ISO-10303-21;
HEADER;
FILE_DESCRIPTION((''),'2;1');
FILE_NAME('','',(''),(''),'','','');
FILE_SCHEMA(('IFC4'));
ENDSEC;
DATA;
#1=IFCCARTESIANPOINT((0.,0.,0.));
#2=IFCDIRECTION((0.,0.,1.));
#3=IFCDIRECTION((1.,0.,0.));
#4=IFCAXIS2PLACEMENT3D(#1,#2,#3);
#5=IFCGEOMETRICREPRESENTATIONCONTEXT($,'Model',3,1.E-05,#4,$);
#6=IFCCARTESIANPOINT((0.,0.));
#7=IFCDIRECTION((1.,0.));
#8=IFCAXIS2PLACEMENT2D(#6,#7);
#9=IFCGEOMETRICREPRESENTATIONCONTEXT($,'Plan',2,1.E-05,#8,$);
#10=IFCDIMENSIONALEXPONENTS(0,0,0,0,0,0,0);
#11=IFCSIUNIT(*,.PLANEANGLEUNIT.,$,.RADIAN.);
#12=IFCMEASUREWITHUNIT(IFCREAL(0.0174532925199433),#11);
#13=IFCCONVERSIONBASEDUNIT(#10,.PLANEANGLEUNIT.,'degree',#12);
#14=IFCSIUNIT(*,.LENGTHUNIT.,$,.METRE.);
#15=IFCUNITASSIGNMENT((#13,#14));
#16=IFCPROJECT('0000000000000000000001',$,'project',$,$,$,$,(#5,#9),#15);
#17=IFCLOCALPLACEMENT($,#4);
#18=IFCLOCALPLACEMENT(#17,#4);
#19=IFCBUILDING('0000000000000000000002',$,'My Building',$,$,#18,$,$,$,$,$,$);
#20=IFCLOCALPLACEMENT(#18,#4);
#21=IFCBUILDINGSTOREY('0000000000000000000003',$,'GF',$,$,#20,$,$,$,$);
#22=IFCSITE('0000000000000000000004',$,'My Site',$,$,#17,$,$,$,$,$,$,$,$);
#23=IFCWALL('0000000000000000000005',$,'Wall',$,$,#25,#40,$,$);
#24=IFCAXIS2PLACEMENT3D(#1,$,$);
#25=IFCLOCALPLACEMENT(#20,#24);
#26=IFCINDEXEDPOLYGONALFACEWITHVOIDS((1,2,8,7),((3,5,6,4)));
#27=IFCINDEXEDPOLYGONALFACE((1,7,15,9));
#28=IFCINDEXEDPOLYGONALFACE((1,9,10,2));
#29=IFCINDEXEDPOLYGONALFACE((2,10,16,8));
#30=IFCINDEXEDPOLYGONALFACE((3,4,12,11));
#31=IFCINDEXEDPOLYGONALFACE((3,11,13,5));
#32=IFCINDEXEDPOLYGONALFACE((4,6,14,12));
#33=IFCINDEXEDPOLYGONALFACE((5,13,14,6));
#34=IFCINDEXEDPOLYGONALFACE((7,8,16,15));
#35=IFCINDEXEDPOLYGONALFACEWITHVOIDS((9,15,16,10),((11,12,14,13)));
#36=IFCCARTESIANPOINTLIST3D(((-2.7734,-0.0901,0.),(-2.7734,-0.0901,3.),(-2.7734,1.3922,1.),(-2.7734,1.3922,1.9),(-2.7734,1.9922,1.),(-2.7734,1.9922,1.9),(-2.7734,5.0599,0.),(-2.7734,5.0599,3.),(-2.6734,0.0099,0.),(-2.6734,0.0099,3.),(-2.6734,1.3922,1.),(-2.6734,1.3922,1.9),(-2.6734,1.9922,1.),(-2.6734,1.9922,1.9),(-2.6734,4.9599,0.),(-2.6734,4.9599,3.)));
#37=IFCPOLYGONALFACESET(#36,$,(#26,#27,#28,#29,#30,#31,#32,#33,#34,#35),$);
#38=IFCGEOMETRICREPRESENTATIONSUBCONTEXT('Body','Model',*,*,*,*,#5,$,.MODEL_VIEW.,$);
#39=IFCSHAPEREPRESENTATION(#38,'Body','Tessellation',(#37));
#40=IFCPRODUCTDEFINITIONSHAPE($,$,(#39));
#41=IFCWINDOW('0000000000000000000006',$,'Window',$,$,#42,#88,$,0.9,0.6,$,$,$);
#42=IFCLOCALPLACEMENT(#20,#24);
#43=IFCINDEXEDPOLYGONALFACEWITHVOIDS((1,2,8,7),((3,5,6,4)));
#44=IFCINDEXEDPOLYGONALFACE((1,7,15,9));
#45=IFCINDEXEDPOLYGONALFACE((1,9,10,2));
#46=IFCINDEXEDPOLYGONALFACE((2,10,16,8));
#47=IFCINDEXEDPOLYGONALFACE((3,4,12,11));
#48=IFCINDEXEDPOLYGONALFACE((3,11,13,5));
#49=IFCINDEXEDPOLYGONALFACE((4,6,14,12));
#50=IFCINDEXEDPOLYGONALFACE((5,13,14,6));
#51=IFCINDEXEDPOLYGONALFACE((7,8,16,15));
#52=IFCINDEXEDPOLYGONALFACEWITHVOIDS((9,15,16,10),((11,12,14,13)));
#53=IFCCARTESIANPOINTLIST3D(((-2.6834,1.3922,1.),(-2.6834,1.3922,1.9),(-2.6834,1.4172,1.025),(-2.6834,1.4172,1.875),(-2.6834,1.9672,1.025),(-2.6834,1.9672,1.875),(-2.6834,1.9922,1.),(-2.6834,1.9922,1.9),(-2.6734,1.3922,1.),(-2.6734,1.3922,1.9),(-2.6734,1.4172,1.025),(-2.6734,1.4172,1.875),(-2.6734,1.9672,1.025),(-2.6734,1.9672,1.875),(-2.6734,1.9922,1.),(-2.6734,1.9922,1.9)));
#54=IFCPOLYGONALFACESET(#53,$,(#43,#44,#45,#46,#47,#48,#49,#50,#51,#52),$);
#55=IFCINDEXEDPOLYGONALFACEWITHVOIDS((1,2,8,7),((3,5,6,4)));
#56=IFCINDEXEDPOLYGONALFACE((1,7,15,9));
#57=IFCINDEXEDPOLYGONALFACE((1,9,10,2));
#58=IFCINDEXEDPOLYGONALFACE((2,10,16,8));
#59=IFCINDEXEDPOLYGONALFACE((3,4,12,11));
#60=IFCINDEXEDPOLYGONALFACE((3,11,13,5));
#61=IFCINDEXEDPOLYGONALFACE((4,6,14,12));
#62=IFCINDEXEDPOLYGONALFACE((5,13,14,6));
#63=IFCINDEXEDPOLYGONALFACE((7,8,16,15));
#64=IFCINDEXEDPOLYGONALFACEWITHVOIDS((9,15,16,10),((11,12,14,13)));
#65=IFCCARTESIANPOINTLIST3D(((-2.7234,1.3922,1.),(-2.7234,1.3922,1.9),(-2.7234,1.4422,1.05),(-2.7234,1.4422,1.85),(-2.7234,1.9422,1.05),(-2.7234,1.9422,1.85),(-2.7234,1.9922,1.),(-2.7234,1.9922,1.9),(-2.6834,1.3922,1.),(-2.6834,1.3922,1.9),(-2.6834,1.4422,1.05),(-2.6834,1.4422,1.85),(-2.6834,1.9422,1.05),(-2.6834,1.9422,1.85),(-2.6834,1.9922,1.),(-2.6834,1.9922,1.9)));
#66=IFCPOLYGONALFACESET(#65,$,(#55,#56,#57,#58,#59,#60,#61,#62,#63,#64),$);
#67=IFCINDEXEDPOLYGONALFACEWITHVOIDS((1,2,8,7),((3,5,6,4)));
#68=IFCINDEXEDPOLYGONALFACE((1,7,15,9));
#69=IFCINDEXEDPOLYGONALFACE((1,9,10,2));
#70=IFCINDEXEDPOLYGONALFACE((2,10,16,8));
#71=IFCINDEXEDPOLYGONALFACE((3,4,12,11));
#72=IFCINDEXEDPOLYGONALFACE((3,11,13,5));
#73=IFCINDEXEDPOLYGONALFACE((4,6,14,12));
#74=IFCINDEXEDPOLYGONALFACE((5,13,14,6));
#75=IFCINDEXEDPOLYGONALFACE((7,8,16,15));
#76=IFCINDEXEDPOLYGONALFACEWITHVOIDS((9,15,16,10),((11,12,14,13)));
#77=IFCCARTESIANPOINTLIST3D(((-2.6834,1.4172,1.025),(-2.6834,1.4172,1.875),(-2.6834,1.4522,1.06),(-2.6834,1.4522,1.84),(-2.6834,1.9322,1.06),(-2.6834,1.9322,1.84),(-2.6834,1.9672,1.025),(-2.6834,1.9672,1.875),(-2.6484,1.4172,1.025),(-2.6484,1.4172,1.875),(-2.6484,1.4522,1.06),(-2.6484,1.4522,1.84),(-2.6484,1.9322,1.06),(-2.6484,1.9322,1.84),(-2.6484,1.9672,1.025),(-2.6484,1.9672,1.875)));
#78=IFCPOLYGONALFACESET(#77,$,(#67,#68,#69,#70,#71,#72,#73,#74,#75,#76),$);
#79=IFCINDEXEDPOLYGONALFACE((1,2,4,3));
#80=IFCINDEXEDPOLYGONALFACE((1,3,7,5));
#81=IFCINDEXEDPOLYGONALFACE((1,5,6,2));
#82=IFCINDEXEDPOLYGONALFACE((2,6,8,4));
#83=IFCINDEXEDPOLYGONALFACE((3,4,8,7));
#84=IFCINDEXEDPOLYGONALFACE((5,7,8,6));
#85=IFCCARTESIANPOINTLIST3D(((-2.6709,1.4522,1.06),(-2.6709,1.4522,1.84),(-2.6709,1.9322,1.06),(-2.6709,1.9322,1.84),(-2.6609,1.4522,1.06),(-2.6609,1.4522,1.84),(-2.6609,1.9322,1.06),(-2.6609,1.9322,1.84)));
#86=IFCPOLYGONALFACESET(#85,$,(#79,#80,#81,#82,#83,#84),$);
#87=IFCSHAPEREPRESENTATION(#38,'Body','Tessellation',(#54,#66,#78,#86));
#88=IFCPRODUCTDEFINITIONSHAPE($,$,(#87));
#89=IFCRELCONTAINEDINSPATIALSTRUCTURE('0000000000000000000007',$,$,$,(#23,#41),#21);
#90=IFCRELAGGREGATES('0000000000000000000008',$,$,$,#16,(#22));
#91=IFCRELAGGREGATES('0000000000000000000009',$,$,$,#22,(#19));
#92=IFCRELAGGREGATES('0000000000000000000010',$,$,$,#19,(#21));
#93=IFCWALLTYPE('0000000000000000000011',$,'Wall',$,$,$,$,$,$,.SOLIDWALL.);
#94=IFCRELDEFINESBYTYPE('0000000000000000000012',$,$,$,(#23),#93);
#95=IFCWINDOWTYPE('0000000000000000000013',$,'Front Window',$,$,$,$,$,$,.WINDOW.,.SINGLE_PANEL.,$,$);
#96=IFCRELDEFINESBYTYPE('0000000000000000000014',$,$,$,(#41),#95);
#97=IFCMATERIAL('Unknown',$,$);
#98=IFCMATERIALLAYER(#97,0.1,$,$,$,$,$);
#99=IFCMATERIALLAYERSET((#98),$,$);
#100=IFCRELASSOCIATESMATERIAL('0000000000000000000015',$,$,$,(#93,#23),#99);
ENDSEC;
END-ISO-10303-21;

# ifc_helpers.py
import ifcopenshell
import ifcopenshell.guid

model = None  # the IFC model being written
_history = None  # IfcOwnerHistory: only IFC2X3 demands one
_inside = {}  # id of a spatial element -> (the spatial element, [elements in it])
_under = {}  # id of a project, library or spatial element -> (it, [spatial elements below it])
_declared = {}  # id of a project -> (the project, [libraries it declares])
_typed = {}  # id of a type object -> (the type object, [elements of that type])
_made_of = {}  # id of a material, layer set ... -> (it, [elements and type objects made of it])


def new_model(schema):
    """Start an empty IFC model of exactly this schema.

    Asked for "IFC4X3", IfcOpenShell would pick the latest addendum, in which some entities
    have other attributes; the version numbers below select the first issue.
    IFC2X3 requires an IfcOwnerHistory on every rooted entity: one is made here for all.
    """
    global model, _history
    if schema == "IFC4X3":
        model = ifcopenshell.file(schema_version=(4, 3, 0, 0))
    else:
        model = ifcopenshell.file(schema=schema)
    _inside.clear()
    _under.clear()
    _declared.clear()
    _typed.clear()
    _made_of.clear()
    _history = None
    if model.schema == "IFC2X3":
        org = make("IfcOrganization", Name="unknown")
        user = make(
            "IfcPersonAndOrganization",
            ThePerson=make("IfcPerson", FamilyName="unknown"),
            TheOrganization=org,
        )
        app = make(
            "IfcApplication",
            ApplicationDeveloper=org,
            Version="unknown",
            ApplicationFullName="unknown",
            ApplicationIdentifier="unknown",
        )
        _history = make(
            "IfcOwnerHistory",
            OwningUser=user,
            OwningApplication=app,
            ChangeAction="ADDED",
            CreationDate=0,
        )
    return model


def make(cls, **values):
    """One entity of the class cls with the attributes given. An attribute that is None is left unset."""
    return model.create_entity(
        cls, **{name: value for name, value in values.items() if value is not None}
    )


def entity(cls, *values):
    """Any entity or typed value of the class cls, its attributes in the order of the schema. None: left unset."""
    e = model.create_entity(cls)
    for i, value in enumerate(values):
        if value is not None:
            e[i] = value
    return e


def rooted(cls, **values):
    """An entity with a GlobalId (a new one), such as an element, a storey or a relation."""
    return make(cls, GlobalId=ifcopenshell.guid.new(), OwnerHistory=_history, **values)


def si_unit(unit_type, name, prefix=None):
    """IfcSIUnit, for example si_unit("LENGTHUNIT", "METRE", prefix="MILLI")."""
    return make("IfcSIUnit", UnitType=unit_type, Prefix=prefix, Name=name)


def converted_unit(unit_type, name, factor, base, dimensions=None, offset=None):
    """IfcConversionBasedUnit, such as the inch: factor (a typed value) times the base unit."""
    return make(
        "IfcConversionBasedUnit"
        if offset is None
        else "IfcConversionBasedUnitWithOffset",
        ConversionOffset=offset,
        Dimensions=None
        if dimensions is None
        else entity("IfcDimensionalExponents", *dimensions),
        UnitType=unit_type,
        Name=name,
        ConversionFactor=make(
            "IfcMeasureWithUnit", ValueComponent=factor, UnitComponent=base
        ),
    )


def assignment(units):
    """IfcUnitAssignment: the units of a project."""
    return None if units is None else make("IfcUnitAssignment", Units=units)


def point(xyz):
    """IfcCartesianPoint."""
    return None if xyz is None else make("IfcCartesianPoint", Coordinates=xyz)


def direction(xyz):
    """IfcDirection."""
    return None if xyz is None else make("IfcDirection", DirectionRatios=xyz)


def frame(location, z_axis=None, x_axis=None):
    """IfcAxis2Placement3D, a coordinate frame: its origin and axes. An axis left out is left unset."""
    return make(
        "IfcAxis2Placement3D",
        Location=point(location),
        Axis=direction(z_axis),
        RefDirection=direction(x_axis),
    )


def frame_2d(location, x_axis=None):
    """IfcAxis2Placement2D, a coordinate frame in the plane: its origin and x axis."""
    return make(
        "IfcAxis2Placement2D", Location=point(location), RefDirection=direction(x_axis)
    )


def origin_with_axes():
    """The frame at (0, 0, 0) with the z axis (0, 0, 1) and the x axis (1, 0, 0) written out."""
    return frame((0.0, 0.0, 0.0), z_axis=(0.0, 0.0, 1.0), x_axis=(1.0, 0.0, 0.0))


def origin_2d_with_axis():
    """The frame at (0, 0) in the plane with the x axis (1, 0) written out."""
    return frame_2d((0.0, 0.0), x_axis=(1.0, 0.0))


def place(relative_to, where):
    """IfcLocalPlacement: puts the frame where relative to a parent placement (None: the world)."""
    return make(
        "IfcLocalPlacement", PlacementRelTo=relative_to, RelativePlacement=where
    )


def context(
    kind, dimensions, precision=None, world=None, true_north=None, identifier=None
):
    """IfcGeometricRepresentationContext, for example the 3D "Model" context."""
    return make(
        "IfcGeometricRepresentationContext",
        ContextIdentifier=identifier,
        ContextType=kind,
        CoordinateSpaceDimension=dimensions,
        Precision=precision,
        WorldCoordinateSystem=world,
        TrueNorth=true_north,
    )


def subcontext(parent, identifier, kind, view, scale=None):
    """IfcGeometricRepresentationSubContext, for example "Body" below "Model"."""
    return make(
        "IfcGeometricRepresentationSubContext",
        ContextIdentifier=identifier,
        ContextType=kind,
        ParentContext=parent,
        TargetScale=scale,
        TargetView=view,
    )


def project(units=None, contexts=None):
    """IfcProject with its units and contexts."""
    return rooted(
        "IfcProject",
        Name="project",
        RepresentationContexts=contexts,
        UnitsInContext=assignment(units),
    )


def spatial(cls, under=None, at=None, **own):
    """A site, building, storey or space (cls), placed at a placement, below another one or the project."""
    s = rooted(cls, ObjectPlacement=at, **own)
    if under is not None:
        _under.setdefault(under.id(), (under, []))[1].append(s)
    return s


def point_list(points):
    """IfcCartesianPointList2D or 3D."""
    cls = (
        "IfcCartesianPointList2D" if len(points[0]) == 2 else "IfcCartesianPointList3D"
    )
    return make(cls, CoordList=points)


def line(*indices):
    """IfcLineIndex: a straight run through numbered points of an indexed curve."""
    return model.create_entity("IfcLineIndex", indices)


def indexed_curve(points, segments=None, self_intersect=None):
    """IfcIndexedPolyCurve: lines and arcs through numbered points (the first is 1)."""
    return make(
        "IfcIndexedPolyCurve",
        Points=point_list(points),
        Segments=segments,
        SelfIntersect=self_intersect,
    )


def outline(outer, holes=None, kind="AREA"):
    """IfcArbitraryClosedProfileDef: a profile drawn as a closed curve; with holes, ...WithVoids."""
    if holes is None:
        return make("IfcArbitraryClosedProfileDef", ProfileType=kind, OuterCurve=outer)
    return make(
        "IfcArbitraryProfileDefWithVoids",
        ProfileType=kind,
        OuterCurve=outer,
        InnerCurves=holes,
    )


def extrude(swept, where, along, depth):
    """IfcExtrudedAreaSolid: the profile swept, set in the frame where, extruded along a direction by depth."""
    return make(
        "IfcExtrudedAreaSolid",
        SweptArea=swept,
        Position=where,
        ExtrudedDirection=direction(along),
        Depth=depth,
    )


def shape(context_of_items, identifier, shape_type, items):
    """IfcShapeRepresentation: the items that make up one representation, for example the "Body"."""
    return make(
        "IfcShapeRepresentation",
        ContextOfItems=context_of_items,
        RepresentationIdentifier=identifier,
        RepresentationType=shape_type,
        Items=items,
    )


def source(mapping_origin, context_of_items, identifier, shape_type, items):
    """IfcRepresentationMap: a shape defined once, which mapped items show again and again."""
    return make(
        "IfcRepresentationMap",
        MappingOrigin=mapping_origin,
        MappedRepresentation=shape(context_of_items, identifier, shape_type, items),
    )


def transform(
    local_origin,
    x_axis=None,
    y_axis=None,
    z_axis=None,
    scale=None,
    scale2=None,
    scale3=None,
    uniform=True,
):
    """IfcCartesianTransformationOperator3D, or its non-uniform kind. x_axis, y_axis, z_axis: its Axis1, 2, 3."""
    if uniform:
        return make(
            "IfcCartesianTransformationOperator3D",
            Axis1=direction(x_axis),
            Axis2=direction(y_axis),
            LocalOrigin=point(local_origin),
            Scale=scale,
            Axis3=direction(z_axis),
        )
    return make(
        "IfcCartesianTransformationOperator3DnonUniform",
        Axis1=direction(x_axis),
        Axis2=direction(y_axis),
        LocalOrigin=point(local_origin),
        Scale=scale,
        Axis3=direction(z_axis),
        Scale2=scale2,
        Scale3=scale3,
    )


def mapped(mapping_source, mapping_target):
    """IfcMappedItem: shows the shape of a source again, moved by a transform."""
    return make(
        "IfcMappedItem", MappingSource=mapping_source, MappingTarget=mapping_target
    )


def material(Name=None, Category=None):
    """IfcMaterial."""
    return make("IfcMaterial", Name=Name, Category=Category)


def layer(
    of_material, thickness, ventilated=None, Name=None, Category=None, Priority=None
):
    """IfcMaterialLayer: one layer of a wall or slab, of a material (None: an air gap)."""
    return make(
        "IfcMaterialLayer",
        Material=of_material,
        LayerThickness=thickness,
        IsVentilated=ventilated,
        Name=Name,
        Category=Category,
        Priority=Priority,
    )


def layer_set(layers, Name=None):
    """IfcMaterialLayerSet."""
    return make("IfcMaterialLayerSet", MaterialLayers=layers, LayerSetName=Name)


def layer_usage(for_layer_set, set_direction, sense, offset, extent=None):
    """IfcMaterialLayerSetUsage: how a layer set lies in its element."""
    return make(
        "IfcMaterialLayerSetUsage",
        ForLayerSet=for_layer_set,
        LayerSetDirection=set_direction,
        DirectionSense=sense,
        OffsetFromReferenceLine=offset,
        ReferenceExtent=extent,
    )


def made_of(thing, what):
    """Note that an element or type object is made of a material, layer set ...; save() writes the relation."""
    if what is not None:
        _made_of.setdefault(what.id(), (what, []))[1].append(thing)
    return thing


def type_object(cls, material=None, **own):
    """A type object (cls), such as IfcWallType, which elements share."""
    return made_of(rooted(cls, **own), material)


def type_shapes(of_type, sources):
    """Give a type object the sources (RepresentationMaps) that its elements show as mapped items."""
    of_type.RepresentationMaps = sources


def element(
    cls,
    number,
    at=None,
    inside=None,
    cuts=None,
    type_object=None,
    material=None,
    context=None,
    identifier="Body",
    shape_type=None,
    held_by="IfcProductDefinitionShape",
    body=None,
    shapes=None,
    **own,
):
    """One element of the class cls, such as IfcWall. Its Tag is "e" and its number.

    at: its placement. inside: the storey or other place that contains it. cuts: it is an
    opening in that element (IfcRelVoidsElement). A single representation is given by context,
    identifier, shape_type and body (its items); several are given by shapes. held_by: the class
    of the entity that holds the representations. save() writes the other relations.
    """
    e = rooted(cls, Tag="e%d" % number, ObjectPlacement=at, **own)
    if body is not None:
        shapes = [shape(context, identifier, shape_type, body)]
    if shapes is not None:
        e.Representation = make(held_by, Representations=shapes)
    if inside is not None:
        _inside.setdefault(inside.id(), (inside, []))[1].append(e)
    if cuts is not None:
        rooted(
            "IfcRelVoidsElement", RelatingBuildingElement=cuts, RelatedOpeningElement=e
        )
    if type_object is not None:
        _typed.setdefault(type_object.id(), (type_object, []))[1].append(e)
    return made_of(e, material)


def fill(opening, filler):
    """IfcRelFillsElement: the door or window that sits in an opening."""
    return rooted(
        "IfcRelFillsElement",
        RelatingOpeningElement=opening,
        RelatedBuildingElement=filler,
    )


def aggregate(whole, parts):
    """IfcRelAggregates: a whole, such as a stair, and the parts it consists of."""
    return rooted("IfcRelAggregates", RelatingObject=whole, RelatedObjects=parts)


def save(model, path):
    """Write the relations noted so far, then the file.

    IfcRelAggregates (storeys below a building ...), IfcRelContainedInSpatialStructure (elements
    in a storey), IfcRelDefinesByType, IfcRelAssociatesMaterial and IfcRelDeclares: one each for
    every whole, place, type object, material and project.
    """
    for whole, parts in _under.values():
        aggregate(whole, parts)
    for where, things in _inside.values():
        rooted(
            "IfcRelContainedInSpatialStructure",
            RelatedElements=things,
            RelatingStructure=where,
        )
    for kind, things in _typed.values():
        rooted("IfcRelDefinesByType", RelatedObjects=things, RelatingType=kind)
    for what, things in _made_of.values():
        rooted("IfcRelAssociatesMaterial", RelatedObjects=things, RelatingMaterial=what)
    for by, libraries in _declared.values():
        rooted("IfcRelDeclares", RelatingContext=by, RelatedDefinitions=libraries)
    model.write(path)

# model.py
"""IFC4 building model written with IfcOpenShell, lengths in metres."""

from ifc_helpers import new_model, entity, si_unit, converted_unit, frame, origin_with_axes, origin_2d_with_axis, place, context, subcontext, project, spatial, line, indexed_curve, outline, extrude, shape, source, transform, mapped, material, layer, layer_set, layer_usage, type_object, type_shapes, element, fill, save


model = new_model("IFC4")

# Units and contexts
model_context = context("Model", 3, precision=1e-05, world=origin_with_axes())
plan_context = context("Plan", 2, precision=1e-05, world=origin_2d_with_axis())
body_context_1 = subcontext(model_context, "Body", "Model", "MODEL_VIEW")
body_context_2 = subcontext(plan_context, "Body", "Plan", "PLAN_VIEW")
ifc_project = project(units=[converted_unit("PLANEANGLEUNIT", "degree", entity("IfcReal", 0.0174532925199433), si_unit("PLANEANGLEUNIT", "RADIAN"), dimensions=[0, 0, 0, 0, 0, 0, 0]), si_unit("LENGTHUNIT", "METRE")], contexts=[model_context, plan_context])

# Site, building, storey
site_placement = place(None, origin_with_axes())
site = spatial("IfcSite", under=ifc_project, at=site_placement, Name="My Site")
building_placement = place(site_placement, origin_with_axes())
building = spatial("IfcBuilding", under=site, at=building_placement, Name="My Building")
storey_placement = place(building_placement, origin_with_axes())
storey = spatial("IfcBuildingStorey", under=building, at=storey_placement, Name="GF")

# Shared definitions
ifc_material_1 = material(Name="Unknown")

# Shared definitions
ifc_layer_1 = layer(ifc_material_1, 0.1)
ifc_layer_set_1 = layer_set([ifc_layer_1])
wall_type = type_object("IfcWallType", Name="Wall", PredefinedType="SOLIDWALL", material=ifc_layer_set_1)
shared_shape_1 = source(origin_with_axes(), body_context_1, "Body", "SweptSolid", [
    extrude(outline(indexed_curve([(0.0, 0.0), (0.6, 0.0), (0.6, 0.9), (0.0, 0.9)], segments=[line(1, 2, 3, 4, 1)])), frame((0.0, -0.6, 0.0), z_axis=(0.0, -1.0, 0.0), x_axis=(1.0, 0.0, 0.0)), (0.0, 0.0, -1.0), 1.2),
])
window_type_1 = type_object("IfcWindowType", Name="Front Window", PartitioningType="SINGLE_PANEL", PredefinedType="WINDOW")
shared_shape_2 = source(origin_with_axes(), body_context_1, "Body", "SweptSolid", [
    extrude(outline(indexed_curve([(0.0, 0.0), (0.6, 0.0), (0.6, 0.9), (0.0, 0.9)], segments=[line(1, 2, 3, 4, 1)]), holes=[indexed_curve([(0.025, 0.025), (0.575, 0.025), (0.575, 0.875), (0.025, 0.875)], segments=[line(1, 2, 3, 4, 1)])]), frame((0.0, 0.09, 0.0), z_axis=(0.0, -1.0, 0.0), x_axis=(1.0, 0.0, 0.0)), (0.0, 0.0, -1.0), 0.01),
    extrude(outline(indexed_curve([(0.0, 0.0), (0.6, 0.0), (0.6, 0.9), (0.0, 0.9)], segments=[line(1, 2, 3, 4, 1)]), holes=[indexed_curve([(0.05, 0.05), (0.55, 0.05), (0.55, 0.85), (0.05, 0.85)], segments=[line(1, 2, 3, 4, 1)])]), frame((0.0, 0.05, 0.0), z_axis=(0.0, -1.0, 0.0), x_axis=(1.0, 0.0, 0.0)), (0.0, 0.0, -1.0), 0.04),
    extrude(outline(indexed_curve([(0.0, 0.0), (0.55, 0.0), (0.55, 0.85), (0.0, 0.85)], segments=[line(1, 2, 3, 4, 1)]), holes=[indexed_curve([(0.035, 0.035), (0.515, 0.035), (0.515, 0.815), (0.035, 0.815)], segments=[line(1, 2, 3, 4, 1)])]), frame((0.025, 0.09, 0.025), z_axis=(0.0, -1.0, 0.0), x_axis=(1.0, 0.0, 0.0)), (0.0, 0.0, -1.0), 0.035),
    extrude(outline(indexed_curve([(0.035, 0.035), (0.515, 0.035), (0.515, 0.815), (0.035, 0.815)], segments=[line(1, 2, 3, 4, 1)])), frame((0.025, 0.1025, 0.025), z_axis=(0.0, -1.0, 0.0), x_axis=(1.0, 0.0, 0.0)), (0.0, 0.0, -1.0), 0.01),
])
shared_shape_3 = source(origin_with_axes(), body_context_2, "Body", "Curve2D", [
    entity("IfcIndexedPolyCurve", entity("IfcCartesianPointList2D", [[0.05, 0.05], [0.55, 0.05]])),
    entity("IfcIndexedPolyCurve", entity("IfcCartesianPointList2D", [[0.0, 0.1], [0.025, 0.1], [0.025, 0.09], [0.05, 0.09], [0.05, 0.05], [0.0, 0.05]]), [entity("IfcLineIndex", [1, 2, 3, 4, 5, 6, 1])]),
    entity("IfcIndexedPolyCurve", entity("IfcCartesianPointList2D", [[0.6, 0.1], [0.575, 0.1], [0.575, 0.09], [0.55, 0.09], [0.55, 0.05], [0.6, 0.05]]), [entity("IfcLineIndex", [1, 2, 3, 4, 5, 6, 1])]),
    entity("IfcIndexedPolyCurve", entity("IfcCartesianPointList2D", [[0.025, 0.09], [0.06, 0.09], [0.06, 0.125], [0.025, 0.125]]), [entity("IfcLineIndex", [1, 2, 3, 4, 1])]),
    entity("IfcIndexedPolyCurve", entity("IfcCartesianPointList2D", [[0.575, 0.09], [0.54, 0.09], [0.54, 0.125], [0.575, 0.125]]), [entity("IfcLineIndex", [1, 2, 3, 4, 1])]),
    entity("IfcIndexedPolyCurve", entity("IfcCartesianPointList2D", [[0.06, 0.09], [0.54, 0.09]])),
    entity("IfcIndexedPolyCurve", entity("IfcCartesianPointList2D", [[0.06, 0.125], [0.54, 0.125]])),
    entity("IfcIndexedPolyCurve", entity("IfcCartesianPointList2D", [[0.06, 0.1075], [0.54, 0.1075]])),
])
type_shapes(window_type_1, [shared_shape_2, shared_shape_3])

# Wall, opening, window
ifc_layer_usage_1 = layer_usage(ifc_layer_set_1, "AXIS2", "POSITIVE", 0.0)
wall_1_placement = place(storey_placement, frame((-2.7734, 5.0599, 0.0), z_axis=(0.0, 0.0, 1.0), x_axis=(0.0, -1.0, 0.0)))
wall_1 = element("IfcWall", 1, at=wall_1_placement, inside=storey, type_object=wall_type, material=ifc_layer_usage_1, Name="Wall", context=body_context_1, shape_type="SweptSolid", body=[
    extrude(outline(indexed_curve([(0.0, 0.0), (0.1, 0.1), (5.05, 0.1), (5.15, 0.0)], segments=[line(1, 2, 3, 4, 1)])), origin_with_axes(), (0.0, 0.0, 1.0), 3.0),
])
opening_1_placement = place(wall_1_placement, frame((3.0677, 0.0, 1.0), z_axis=(0.0, 0.0, 1.0), x_axis=(1.0, 0.0, 0.0)))
opening_1 = element("IfcOpeningElement", 2, at=opening_1_placement, cuts=wall_1, PredefinedType="OPENING", context=body_context_1, shape_type="MappedRepresentation", body=[
    mapped(shared_shape_1, transform((0.0, 0.0, 0.0), x_axis=(1.0, 0.0, 0.0), y_axis=(0.0, 1.0, 0.0), z_axis=(0.0, 0.0, 1.0), scale=1.0)),
])
window_1_placement = place(opening_1_placement, frame((0.0, 0.0, 0.0), z_axis=(0.0, 0.0, 1.0), x_axis=(1.0, 0.0, 0.0)))
window_1 = element("IfcWindow", 3, at=window_1_placement, inside=storey, type_object=window_type_1, Name="Window", OverallHeight=0.9, OverallWidth=0.6, shapes=[
    shape(body_context_1, "Body", "MappedRepresentation", [mapped(shared_shape_2, transform((0.0, 0.0, 0.0), x_axis=(1.0, 0.0, 0.0), y_axis=(0.0, 1.0, 0.0), z_axis=(0.0, 0.0, 1.0), scale=1.0))]),
    shape(body_context_2, "Body", "MappedRepresentation", [mapped(shared_shape_3, transform((0.0, 0.0, 0.0), x_axis=(1.0, 0.0, 0.0), y_axis=(0.0, 1.0, 0.0), z_axis=(0.0, 0.0, 1.0), scale=1.0))]),
])
fill(opening_1, window_1)

save(model, "model.ifc")
